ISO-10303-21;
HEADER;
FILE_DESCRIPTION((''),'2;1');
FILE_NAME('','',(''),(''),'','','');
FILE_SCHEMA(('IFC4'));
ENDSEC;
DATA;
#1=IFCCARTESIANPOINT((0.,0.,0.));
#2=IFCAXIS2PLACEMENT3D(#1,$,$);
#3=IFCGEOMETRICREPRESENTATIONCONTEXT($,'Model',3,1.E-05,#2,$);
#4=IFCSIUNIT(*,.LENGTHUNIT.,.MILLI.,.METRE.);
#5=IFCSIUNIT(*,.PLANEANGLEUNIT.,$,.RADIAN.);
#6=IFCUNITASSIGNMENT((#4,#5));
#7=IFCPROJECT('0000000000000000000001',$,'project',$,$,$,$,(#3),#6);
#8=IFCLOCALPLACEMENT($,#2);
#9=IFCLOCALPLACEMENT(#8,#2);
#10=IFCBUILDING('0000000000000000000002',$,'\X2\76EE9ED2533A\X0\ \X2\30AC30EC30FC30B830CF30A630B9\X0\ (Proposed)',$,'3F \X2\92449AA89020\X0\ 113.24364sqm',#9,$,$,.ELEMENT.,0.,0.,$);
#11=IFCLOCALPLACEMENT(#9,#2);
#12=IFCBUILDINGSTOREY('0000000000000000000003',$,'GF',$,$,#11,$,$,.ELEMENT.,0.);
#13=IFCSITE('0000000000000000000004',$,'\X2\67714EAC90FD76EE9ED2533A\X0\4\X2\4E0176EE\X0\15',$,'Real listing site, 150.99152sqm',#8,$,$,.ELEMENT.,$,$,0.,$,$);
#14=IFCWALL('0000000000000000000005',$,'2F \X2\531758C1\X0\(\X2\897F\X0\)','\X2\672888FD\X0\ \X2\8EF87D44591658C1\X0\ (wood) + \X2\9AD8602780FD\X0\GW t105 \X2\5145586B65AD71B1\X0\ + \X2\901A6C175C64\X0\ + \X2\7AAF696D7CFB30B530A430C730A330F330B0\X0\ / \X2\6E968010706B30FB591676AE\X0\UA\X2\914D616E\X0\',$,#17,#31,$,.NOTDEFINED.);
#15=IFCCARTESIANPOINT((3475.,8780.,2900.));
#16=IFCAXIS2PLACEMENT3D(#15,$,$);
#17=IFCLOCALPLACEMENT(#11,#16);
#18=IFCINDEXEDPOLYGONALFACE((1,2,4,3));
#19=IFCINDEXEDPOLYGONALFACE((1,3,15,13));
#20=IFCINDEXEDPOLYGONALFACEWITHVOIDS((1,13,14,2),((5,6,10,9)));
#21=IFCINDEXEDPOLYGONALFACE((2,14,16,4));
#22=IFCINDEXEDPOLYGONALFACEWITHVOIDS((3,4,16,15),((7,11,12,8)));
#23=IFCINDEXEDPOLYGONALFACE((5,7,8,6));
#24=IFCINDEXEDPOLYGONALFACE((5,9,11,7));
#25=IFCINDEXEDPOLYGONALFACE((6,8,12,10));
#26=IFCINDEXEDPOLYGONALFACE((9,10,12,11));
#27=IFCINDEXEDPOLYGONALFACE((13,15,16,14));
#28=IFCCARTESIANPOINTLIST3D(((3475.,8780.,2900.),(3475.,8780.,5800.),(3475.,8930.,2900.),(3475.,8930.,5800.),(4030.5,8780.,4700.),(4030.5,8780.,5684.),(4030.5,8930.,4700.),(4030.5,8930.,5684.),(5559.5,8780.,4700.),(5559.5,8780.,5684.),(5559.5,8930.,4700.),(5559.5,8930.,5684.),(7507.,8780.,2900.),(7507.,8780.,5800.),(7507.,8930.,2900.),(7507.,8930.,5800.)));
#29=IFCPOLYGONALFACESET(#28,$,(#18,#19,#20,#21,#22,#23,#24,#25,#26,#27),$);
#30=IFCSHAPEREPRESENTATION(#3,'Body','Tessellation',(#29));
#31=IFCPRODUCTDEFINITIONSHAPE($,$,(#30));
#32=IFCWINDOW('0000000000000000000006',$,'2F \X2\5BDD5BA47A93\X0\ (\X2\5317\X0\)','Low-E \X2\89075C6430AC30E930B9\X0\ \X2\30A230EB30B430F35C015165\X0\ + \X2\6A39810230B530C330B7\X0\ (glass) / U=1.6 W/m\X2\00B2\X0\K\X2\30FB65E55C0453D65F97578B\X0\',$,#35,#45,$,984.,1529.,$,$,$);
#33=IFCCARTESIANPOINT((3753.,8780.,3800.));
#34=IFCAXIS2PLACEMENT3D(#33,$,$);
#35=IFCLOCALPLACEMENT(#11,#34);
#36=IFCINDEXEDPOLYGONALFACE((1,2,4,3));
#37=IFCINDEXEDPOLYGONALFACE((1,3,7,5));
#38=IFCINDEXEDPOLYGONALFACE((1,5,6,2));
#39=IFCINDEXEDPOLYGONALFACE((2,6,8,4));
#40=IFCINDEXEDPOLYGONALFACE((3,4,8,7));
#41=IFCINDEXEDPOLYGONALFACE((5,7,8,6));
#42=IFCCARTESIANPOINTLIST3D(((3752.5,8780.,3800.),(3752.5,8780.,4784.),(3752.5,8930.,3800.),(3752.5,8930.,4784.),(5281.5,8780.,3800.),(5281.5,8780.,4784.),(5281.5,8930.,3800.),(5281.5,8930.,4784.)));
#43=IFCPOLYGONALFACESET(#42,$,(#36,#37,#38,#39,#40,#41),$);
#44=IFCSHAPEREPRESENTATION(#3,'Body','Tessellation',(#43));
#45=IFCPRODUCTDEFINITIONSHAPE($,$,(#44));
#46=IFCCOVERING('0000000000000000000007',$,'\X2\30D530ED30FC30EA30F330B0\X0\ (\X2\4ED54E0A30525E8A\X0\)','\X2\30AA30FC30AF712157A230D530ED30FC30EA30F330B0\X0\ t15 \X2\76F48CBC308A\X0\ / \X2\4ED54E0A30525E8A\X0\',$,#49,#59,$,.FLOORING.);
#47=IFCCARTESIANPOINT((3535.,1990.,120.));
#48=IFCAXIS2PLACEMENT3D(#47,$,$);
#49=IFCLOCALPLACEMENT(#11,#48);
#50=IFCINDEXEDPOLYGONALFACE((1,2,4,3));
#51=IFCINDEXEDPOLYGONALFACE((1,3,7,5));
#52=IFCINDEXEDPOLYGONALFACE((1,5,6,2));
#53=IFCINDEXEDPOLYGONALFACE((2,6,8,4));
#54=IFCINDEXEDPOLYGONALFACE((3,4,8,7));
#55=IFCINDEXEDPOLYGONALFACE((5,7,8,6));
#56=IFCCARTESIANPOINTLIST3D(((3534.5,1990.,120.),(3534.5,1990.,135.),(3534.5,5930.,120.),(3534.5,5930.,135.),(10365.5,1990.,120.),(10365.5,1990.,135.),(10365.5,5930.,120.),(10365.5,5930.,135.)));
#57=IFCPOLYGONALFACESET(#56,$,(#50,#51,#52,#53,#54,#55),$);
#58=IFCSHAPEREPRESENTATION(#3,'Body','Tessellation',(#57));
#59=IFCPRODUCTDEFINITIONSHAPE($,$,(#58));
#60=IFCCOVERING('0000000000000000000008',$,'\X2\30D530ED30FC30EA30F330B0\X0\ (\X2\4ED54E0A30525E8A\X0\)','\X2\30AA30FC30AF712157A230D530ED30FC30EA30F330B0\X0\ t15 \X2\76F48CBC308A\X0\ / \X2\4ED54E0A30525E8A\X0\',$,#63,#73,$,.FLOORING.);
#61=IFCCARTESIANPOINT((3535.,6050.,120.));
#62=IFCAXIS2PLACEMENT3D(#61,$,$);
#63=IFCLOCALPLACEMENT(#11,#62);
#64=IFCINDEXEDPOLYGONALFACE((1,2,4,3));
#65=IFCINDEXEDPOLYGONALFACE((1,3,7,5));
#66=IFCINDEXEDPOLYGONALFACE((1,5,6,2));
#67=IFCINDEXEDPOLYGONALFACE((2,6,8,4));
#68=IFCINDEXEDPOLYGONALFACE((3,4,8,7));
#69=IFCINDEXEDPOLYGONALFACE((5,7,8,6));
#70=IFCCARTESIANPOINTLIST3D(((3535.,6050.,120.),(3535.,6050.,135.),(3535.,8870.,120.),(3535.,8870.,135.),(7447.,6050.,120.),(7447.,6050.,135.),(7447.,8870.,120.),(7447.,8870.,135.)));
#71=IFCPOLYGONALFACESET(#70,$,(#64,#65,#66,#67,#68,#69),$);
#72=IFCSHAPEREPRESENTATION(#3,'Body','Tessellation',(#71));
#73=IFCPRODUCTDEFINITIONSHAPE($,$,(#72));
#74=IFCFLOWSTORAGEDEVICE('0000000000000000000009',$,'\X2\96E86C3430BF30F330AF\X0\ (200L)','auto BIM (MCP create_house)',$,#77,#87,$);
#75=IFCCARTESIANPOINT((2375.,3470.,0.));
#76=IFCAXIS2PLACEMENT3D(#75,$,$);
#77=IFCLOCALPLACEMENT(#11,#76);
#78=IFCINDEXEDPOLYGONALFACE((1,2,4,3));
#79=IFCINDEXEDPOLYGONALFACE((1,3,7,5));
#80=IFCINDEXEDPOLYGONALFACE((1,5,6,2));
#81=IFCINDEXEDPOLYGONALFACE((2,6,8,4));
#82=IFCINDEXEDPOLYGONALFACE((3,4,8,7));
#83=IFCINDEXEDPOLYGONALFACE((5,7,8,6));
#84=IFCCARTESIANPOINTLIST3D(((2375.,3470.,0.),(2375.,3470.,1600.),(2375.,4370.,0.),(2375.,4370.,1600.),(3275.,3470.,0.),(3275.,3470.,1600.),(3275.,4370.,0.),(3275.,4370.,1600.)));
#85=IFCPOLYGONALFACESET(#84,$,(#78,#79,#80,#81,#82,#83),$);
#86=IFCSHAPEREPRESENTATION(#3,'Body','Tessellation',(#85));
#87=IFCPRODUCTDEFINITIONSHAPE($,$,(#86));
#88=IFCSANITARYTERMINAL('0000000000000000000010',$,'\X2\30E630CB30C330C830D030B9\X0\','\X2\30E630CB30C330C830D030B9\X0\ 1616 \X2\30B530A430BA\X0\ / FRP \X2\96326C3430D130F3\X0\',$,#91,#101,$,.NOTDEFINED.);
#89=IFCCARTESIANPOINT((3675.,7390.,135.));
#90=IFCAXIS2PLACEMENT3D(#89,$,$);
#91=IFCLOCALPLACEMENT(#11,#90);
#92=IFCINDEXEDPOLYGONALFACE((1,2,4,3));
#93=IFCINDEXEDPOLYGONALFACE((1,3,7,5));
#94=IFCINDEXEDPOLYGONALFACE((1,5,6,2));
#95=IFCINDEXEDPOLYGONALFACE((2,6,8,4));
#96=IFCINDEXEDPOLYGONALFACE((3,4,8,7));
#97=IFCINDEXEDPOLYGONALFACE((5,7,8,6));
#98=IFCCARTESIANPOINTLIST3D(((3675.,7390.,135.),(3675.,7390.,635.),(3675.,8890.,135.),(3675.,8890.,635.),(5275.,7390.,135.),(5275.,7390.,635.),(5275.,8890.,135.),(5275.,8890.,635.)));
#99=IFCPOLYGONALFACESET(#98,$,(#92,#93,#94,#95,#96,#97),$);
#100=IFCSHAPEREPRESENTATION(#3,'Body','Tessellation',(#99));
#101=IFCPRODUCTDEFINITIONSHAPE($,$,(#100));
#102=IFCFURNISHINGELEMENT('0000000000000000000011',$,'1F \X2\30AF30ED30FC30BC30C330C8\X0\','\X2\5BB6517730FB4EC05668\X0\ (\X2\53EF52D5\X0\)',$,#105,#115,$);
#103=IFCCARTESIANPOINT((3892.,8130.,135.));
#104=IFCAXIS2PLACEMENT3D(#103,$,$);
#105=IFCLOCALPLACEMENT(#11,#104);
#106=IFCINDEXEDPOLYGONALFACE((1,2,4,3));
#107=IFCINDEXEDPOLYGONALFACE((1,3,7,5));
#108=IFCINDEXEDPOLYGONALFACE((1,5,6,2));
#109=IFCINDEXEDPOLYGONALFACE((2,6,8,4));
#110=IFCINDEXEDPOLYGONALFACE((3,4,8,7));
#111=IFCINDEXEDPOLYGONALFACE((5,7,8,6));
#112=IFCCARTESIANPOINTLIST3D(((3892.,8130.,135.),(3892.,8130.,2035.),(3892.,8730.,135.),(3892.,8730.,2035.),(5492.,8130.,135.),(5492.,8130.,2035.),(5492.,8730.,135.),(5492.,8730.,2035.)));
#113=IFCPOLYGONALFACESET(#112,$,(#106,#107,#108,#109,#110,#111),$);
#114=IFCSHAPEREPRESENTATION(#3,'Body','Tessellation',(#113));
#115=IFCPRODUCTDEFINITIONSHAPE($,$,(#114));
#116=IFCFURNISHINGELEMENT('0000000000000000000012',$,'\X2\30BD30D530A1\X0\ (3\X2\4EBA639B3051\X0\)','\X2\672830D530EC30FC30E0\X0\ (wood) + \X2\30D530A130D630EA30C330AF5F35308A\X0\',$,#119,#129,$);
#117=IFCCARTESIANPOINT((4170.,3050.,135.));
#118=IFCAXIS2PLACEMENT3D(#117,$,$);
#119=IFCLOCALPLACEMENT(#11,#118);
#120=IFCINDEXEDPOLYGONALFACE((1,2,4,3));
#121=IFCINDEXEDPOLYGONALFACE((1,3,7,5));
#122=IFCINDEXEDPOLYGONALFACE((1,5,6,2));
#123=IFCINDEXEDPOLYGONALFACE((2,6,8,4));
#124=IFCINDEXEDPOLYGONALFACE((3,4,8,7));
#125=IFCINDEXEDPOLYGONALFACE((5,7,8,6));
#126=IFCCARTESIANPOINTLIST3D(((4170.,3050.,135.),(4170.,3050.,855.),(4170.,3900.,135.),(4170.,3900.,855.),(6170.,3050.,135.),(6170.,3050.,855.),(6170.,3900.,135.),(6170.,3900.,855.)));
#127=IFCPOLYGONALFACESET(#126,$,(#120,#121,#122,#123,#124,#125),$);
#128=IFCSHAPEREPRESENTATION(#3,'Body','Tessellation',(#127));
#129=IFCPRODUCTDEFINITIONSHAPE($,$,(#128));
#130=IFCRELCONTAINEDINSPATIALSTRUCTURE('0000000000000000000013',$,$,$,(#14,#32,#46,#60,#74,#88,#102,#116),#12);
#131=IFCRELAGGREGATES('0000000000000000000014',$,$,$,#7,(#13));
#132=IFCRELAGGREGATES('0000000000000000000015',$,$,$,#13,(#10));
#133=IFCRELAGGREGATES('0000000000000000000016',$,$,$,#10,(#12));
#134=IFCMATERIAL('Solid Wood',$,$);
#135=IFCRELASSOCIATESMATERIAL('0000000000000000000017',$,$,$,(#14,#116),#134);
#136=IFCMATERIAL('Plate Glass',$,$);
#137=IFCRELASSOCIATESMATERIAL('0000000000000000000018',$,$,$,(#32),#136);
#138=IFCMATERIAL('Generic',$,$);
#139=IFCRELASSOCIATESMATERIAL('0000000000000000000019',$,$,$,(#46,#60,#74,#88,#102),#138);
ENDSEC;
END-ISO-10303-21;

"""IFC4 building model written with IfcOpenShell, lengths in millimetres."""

from ifc_helpers import new_model, si_unit, frame, frame_2d, origin, place, context, project, spatial, rectangle, extrude, material, element, fill, save


model = new_model("IFC4")

# Units and contexts
model_context = context("Model", 3, precision=1e-05, world=origin())
ifc_project = project(units=[si_unit("LENGTHUNIT", "METRE", prefix="MILLI"), si_unit("PLANEANGLEUNIT", "RADIAN")], contexts=[model_context])

# Site, building, storey
site_placement = place(None, origin())
site = spatial("IfcSite", under=ifc_project, at=site_placement, Name="東京都目黒区4丁目15", ObjectType="Real listing site, 150.99152sqm", CompositionType="ELEMENT", RefElevation=0.0)
building_placement = place(site_placement, origin())
building = spatial("IfcBuilding", under=site, at=building_placement, Name="目黒区 ガレージハウス (Proposed)", ObjectType="3F 鉄骨造 113.24364sqm", CompositionType="ELEMENT", ElevationOfRefHeight=0.0, ElevationOfTerrain=0.0)
storey_placement = place(building_placement, origin())
storey = spatial("IfcBuildingStorey", under=building, at=storey_placement, Name="GF", CompositionType="ELEMENT", Elevation=0.0)

# Shared definitions
ifc_material_1 = material(Name="Solid Wood")

# Shared definitions
ifc_material_2 = material(Name="Plate Glass")

# Wall, opening, window
wall_1_placement = place(storey_placement, frame((3475.0, 8780.0, 2900.0)))
wall_1 = element("IfcWall", 1, at=wall_1_placement, inside=storey, material=ifc_material_1, Name="2F 北壁(西)", Description="木製 軸組外壁 (wood) + 高性能GW t105 充填断熱 + 通気層 + 窯業系サイディング / 準耐火・外皮UA配慮", PredefinedType="NOTDEFINED", context=model_context, shape_type="SweptSolid", body=[
    extrude(rectangle(XDim=4032.0, YDim=150.0, at=frame_2d((2016.0, 75.0))), frame((3475.0, 8780.0, 2900.0)), (0.0, 0.0, 1.0), 2900.0),
])
opening_1_placement = place(storey_placement, frame((3753.0, 8780.0, 3800.0)))
opening_1 = element("IfcOpeningElement", 2, at=opening_1_placement, cuts=wall_1, PredefinedType="NOTDEFINED", context=model_context, shape_type="SweptSolid", body=[
    extrude(rectangle(XDim=1529.0, YDim=150.0, at=frame_2d((764.0, 75.0))), frame((3753.0, 8780.0, 3800.0)), (0.0, 0.0, 1.0), 984.0),
])
window_1_placement = place(storey_placement, frame((3753.0, 8780.0, 3800.0)))
window_1 = element("IfcWindow", 3, at=window_1_placement, inside=storey, material=ifc_material_2, Name="2F 寝室窓 (北)", Description="Low-E 複層ガラス アルゴン封入 + 樹脂サッシ (glass) / U=1.6 W/m²K・日射取得型", OverallHeight=984.0, OverallWidth=1529.0, context=model_context, shape_type="SweptSolid", body=[
    extrude(rectangle(XDim=1529.0, YDim=150.0, at=frame_2d((764.0, 75.0))), frame((3753.0, 8780.0, 3800.0)), (0.0, 0.0, 1.0), 984.0),
])
fill(opening_1, window_1)

# Coverings
ifc_material_3 = material(Name="Generic")
covering_1_placement = place(storey_placement, frame((3535.0, 1990.0, 120.0)))
element("IfcCovering", 4, at=covering_1_placement, inside=storey, material=ifc_material_3, Name="フローリング (仕上げ床)", Description="オーク無垢フローリング t15 直貼り / 仕上げ床", PredefinedType="FLOORING", context=model_context, shape_type="SweptSolid", body=[
    extrude(rectangle(XDim=6831.0, YDim=3940.0, at=frame_2d((3415.0, 1970.0))), frame((3535.0, 1990.0, 120.0)), (0.0, 0.0, 1.0), 15.0),
])
covering_2_placement = place(storey_placement, frame((3535.0, 6050.0, 120.0)))
element("IfcCovering", 5, at=covering_2_placement, inside=storey, material=ifc_material_3, Name="フローリング (仕上げ床)", Description="オーク無垢フローリング t15 直貼り / 仕上げ床", PredefinedType="FLOORING", context=model_context, shape_type="SweptSolid", body=[
    extrude(rectangle(XDim=3912.0, YDim=2820.0, at=frame_2d((1956.0, 1410.0))), frame((3535.0, 6050.0, 120.0)), (0.0, 0.0, 1.0), 15.0),
])

# Flow storage device
flow_storage_device_placement = place(storey_placement, frame((2375.0, 3470.0, 0.0)))
element("IfcFlowStorageDevice", 6, at=flow_storage_device_placement, inside=storey, material=ifc_material_3, Name="雨水タンク (200L)", Description="auto BIM (MCP create_house)", context=model_context, shape_type="SweptSolid", body=[
    extrude(rectangle(XDim=900.0, YDim=900.0, at=frame_2d((450.0, 450.0))), frame((2375.0, 3470.0, 0.0)), (0.0, 0.0, 1.0), 1600.0),
])

# Sanitary terminal
sanitary_terminal_placement = place(storey_placement, frame((3675.0, 7390.0, 135.0)))
element("IfcSanitaryTerminal", 7, at=sanitary_terminal_placement, inside=storey, material=ifc_material_3, Name="ユニットバス", Description="ユニットバス 1616 サイズ / FRP 防水パン", PredefinedType="NOTDEFINED", context=model_context, shape_type="SweptSolid", body=[
    extrude(rectangle(XDim=1600.0, YDim=1500.0, at=frame_2d((800.0, 750.0))), frame((3675.0, 7390.0, 135.0)), (0.0, 0.0, 1.0), 500.0),
])

# Furnishing elements
furnishing_1_placement = place(storey_placement, frame((3892.0, 8130.0, 135.0)))
element("IfcFurnishingElement", 8, at=furnishing_1_placement, inside=storey, material=ifc_material_3, Name="1F クローゼット", Description="家具・什器 (可動)", context=model_context, shape_type="SweptSolid", body=[
    extrude(rectangle(XDim=1600.0, YDim=600.0, at=frame_2d((800.0, 300.0))), frame((3892.0, 8130.0, 135.0)), (0.0, 0.0, 1.0), 1900.0),
])
furnishing_2_placement = place(storey_placement, frame((4170.0, 3050.0, 135.0)))
element("IfcFurnishingElement", 9, at=furnishing_2_placement, inside=storey, material=ifc_material_1, Name="ソファ (3人掛け)", Description="木フレーム (wood) + ファブリック張り", context=model_context, shape_type="SweptSolid", body=[
    extrude(rectangle(XDim=2000.0, YDim=850.0, at=frame_2d((1000.0, 425.0))), frame((4170.0, 3050.0, 135.0)), (0.0, 0.0, 1.0), 720.0),
])

save(model, "model.ifc")
